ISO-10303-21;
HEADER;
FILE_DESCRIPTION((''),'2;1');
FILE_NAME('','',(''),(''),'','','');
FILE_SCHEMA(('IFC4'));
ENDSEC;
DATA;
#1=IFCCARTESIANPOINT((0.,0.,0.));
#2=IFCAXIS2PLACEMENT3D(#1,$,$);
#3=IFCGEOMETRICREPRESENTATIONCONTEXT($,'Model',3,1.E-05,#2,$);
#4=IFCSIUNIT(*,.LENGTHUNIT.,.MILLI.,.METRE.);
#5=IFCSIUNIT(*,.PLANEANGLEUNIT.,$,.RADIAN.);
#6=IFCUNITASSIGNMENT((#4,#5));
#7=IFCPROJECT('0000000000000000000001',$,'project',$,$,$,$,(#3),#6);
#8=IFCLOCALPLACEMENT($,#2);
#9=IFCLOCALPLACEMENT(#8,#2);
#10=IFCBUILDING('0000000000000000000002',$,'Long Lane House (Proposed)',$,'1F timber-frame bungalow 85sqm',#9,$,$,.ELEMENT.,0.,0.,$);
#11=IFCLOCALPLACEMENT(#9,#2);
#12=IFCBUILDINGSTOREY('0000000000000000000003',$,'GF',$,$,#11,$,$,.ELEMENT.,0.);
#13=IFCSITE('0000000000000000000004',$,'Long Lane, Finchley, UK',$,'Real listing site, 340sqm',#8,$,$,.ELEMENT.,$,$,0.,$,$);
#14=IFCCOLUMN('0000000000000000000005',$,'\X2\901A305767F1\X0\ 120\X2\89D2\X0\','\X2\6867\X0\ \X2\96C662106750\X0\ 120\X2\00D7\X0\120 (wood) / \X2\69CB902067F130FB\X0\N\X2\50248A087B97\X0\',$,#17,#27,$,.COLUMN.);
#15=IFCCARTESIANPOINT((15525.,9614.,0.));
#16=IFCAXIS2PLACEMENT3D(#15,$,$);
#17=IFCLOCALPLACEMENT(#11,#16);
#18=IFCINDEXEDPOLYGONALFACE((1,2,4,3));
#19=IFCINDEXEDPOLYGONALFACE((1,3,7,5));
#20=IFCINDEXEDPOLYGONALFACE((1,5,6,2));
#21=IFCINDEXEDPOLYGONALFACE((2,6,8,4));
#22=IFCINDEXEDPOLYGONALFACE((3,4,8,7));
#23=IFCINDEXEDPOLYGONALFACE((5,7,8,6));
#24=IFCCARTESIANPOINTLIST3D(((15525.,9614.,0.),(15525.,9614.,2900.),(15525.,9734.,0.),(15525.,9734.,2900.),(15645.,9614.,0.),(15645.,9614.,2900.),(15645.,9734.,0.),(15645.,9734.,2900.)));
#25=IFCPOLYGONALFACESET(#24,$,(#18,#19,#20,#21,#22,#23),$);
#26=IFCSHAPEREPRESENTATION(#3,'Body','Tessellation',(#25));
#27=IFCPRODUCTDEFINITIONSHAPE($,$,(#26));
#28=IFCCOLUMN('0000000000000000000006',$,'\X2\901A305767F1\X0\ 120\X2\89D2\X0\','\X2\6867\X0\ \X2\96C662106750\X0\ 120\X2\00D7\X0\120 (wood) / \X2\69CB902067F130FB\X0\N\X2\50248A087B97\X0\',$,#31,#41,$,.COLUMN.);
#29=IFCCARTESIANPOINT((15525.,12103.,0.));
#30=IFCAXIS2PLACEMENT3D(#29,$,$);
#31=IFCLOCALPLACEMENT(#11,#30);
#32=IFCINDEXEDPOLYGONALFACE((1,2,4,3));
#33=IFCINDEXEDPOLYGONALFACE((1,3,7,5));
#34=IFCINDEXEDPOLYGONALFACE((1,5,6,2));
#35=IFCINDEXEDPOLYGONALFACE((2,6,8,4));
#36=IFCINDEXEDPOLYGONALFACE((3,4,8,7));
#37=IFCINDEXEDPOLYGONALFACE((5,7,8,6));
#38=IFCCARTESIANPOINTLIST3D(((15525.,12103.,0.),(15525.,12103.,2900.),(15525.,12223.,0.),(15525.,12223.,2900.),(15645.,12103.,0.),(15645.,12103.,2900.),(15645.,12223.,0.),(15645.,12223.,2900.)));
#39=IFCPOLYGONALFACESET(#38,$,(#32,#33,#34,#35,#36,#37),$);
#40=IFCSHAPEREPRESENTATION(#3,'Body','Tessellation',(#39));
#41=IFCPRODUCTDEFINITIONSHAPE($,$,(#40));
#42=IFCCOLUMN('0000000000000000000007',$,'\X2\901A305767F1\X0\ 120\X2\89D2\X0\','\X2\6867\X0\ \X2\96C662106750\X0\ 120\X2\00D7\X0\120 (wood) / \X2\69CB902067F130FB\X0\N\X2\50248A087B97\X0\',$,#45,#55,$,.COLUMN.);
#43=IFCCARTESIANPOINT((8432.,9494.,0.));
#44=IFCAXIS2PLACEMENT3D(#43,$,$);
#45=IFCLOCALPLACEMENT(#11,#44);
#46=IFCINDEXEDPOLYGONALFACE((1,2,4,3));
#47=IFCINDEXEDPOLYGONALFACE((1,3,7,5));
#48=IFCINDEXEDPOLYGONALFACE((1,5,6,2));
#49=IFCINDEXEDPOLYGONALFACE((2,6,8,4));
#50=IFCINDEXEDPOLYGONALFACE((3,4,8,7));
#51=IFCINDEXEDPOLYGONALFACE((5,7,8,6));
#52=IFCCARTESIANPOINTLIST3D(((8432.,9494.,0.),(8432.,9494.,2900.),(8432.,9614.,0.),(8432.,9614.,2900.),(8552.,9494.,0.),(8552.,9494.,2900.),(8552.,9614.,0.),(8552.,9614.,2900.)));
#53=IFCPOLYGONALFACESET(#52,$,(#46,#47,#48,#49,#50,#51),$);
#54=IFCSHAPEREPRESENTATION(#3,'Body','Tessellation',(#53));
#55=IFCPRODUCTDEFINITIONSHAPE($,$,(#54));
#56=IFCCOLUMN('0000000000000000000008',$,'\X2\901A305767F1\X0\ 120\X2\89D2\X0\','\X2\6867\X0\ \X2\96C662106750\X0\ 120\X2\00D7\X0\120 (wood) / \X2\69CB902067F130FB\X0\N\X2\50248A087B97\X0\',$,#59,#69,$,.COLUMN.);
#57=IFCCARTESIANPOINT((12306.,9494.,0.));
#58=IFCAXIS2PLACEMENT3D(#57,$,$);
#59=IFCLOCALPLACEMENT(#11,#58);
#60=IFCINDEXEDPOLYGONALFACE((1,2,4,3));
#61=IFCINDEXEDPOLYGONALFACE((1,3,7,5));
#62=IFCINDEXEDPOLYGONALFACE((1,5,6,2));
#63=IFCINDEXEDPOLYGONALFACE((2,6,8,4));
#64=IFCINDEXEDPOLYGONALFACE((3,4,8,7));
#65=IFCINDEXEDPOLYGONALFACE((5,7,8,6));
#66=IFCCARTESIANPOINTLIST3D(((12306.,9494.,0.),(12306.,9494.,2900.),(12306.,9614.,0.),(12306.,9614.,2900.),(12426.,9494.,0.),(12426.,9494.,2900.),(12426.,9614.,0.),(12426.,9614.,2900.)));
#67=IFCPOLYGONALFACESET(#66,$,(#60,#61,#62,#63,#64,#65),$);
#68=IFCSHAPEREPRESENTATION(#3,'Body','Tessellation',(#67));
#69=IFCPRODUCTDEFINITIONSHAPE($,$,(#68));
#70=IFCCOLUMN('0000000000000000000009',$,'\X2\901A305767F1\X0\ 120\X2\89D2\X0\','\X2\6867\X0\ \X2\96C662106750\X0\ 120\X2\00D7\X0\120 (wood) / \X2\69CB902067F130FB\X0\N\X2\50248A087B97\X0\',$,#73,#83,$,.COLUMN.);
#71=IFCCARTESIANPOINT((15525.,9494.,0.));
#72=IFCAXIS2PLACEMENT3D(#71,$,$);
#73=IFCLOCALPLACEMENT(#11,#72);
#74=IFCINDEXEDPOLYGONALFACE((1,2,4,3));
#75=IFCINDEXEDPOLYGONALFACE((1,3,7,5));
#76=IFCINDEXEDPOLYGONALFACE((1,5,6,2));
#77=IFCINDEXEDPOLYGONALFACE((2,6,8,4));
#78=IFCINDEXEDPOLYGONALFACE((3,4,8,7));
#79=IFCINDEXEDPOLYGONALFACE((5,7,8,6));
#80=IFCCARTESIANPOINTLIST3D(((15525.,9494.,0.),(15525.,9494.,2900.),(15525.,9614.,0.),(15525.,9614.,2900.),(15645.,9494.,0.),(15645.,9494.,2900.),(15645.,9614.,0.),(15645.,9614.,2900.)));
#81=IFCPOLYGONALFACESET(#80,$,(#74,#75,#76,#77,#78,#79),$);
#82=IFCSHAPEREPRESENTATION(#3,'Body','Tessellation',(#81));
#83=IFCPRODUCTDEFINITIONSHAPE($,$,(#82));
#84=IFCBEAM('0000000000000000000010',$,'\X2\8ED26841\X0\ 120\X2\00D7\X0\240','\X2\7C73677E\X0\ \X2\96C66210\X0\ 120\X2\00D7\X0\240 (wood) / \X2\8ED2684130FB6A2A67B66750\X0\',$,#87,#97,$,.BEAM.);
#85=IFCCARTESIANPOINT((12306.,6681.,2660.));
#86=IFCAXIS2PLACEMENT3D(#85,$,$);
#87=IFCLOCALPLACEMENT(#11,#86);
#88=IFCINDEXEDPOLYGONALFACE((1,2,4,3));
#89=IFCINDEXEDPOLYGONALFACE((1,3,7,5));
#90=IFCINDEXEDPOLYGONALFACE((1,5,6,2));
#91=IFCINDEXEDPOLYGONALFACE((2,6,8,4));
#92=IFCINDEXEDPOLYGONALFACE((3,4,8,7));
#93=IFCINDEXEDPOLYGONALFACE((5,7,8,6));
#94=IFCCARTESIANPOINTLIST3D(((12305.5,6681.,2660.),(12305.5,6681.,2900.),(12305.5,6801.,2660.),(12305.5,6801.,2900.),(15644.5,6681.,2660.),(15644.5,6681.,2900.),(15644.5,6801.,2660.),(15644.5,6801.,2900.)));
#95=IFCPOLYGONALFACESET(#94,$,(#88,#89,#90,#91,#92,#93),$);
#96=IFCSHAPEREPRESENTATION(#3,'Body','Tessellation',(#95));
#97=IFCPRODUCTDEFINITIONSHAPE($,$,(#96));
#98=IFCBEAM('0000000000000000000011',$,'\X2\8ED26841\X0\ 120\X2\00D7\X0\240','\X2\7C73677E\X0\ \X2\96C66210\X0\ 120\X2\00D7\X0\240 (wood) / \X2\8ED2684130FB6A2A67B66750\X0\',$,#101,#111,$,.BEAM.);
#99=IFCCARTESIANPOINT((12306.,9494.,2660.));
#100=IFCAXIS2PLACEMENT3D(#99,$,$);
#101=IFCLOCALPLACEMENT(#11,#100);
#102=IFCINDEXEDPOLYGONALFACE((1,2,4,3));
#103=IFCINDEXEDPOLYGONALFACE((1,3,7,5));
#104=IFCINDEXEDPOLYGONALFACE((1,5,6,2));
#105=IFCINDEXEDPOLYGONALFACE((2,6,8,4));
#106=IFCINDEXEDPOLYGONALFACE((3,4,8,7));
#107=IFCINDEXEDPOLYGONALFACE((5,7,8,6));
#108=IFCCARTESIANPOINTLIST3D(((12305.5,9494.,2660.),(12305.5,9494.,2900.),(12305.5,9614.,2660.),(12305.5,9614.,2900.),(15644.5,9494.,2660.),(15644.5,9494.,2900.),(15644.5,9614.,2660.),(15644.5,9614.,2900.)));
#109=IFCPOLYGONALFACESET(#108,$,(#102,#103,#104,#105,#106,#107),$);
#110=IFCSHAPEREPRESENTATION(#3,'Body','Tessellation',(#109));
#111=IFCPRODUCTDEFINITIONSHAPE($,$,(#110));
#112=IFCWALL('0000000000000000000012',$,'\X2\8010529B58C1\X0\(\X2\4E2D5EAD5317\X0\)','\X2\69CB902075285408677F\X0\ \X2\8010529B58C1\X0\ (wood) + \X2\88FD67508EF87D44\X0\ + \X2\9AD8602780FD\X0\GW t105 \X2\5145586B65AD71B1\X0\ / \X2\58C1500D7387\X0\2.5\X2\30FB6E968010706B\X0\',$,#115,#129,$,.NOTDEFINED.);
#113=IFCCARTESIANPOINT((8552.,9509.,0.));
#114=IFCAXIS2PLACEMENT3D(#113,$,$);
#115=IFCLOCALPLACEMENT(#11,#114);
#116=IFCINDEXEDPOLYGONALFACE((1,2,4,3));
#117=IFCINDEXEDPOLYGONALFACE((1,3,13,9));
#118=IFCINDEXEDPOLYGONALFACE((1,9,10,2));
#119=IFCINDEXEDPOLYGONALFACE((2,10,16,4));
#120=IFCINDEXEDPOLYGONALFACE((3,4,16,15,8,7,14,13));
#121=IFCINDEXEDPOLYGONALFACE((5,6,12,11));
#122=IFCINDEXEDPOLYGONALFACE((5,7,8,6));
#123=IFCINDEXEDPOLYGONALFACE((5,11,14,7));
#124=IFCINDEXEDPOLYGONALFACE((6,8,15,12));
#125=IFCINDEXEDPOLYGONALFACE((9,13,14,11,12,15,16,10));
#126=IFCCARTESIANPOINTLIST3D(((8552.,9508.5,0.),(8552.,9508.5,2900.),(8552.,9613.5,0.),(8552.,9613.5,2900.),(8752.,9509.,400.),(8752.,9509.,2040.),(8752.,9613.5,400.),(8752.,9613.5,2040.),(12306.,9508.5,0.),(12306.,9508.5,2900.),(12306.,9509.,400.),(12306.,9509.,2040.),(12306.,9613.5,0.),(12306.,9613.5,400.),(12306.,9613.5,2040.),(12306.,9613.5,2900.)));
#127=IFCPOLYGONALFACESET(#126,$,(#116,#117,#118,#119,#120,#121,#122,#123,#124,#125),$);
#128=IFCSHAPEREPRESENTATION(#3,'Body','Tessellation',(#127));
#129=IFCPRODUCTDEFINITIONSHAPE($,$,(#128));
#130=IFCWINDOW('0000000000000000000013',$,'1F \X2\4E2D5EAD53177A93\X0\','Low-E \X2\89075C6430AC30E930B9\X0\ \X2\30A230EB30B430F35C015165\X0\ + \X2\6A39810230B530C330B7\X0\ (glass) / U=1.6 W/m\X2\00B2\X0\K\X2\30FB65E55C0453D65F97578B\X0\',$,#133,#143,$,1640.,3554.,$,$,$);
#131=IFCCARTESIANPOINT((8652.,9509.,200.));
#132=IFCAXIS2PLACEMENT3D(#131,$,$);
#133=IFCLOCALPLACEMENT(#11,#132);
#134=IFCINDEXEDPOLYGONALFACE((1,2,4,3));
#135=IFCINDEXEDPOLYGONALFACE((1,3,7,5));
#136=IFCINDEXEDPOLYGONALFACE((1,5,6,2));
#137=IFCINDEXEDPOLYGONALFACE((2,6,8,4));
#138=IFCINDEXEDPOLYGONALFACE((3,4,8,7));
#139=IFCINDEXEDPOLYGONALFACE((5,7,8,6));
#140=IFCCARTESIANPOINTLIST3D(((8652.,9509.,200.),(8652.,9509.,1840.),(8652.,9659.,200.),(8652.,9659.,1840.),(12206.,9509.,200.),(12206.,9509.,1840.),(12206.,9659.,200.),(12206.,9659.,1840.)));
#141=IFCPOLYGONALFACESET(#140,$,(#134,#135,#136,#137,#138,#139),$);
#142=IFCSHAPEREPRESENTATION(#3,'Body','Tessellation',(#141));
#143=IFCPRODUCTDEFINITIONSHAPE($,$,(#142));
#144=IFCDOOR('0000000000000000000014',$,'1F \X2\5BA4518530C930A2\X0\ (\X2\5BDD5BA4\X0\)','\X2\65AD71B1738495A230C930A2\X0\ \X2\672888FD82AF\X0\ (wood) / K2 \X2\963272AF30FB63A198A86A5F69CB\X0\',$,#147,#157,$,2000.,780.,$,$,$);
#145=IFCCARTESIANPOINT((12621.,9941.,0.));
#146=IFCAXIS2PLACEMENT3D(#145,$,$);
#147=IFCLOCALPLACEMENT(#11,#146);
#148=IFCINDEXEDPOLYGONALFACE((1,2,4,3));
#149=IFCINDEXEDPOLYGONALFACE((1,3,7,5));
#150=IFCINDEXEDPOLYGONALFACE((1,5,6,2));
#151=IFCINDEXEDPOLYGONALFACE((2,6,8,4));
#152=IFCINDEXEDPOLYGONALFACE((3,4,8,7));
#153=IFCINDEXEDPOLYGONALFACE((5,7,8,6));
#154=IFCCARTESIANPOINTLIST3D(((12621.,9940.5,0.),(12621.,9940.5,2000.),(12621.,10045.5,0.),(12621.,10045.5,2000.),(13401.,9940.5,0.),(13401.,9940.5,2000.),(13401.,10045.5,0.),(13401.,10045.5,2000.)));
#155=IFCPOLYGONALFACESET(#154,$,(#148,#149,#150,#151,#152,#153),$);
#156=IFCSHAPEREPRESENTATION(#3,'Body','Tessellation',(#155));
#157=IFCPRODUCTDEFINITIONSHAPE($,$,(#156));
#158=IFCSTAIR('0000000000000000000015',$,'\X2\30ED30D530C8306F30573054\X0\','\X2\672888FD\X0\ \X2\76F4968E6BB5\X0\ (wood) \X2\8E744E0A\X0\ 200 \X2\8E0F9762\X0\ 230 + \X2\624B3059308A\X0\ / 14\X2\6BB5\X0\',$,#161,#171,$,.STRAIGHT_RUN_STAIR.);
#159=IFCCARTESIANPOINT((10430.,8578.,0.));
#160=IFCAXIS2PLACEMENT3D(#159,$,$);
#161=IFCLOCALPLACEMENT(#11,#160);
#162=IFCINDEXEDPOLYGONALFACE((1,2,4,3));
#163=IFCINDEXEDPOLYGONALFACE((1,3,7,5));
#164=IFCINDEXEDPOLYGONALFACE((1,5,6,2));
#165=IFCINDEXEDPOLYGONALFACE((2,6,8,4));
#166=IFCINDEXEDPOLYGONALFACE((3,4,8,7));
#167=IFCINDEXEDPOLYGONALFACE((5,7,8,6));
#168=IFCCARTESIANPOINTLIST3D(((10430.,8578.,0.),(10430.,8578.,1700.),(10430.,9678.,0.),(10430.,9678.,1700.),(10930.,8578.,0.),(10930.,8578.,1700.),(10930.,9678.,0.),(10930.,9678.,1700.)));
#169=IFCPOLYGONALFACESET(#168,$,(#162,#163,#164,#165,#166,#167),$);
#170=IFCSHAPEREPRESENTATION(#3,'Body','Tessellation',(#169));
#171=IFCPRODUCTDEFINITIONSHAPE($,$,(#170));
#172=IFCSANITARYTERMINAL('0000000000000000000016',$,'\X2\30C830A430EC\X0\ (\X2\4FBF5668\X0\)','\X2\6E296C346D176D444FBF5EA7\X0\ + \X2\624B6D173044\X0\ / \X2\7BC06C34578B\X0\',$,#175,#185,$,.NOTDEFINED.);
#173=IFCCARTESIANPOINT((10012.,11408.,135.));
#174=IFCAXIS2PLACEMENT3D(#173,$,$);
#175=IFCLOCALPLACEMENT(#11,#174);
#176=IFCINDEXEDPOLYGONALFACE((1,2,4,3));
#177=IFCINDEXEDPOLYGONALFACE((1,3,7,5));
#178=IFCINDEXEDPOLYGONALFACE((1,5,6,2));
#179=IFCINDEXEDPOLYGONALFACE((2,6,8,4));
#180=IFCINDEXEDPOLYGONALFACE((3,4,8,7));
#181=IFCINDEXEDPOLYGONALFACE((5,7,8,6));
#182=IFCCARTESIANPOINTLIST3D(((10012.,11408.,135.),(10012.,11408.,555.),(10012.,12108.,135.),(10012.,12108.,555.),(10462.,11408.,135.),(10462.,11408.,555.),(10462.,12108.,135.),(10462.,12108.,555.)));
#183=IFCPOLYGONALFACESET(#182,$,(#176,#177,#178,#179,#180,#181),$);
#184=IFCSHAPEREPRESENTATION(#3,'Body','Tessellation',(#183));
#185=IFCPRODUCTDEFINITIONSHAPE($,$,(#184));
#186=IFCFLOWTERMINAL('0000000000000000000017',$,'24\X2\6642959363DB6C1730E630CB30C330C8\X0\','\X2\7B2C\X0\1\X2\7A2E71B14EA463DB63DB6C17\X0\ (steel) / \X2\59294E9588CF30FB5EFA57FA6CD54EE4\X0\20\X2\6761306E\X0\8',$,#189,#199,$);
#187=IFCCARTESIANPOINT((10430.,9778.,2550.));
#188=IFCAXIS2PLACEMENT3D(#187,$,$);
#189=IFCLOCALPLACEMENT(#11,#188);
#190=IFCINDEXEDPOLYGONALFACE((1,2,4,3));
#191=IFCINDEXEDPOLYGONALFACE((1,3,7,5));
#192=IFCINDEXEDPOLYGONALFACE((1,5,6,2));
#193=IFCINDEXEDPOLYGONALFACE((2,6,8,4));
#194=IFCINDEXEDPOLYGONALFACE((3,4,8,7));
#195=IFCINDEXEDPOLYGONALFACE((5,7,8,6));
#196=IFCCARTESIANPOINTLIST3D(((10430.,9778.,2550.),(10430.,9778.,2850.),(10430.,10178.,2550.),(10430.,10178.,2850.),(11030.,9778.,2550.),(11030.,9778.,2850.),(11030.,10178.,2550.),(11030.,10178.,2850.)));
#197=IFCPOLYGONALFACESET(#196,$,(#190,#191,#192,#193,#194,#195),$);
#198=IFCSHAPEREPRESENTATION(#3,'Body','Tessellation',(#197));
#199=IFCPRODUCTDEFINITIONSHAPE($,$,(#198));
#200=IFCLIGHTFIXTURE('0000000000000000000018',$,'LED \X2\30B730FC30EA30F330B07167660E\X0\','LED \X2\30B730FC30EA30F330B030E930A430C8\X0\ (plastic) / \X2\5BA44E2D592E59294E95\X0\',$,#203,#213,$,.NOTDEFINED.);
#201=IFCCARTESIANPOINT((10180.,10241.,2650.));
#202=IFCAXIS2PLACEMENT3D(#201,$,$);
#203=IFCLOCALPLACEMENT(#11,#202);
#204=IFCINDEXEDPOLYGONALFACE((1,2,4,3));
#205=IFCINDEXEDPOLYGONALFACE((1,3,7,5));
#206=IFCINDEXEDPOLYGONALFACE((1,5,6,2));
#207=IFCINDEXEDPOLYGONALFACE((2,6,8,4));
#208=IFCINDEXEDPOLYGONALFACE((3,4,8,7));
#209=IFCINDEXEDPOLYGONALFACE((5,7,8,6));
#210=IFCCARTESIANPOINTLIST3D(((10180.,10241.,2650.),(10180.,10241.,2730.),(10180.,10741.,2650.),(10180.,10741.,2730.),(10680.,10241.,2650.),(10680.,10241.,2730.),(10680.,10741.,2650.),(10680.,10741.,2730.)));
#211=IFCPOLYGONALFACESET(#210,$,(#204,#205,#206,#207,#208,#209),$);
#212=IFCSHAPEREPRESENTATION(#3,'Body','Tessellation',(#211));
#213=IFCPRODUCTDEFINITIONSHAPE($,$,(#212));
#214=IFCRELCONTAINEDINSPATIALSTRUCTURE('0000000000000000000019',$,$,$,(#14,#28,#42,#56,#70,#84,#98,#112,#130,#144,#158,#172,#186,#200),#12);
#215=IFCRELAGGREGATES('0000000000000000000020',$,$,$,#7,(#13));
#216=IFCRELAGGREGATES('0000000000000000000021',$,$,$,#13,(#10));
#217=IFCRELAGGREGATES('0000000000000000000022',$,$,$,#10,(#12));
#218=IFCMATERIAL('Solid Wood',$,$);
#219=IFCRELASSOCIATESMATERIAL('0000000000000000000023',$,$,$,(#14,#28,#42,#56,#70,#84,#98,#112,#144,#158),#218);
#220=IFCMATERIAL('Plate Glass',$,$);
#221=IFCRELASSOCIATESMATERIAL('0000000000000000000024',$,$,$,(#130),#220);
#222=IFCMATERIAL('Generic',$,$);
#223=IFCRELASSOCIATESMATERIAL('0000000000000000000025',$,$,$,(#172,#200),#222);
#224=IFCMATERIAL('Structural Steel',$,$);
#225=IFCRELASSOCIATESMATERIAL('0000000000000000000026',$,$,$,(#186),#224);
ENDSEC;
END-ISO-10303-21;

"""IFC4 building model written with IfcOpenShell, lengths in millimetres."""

from ifc_helpers import new_model, si_unit, frame, frame_2d, origin, place, context, project, spatial, rectangle, extrude, material, element, fill, save


model = new_model("IFC4")

# Units and contexts
model_context = context("Model", 3, precision=1e-05, world=origin())
ifc_project = project(units=[si_unit("LENGTHUNIT", "METRE", prefix="MILLI"), si_unit("PLANEANGLEUNIT", "RADIAN")], contexts=[model_context])

# Site, building, storey
site_placement = place(None, origin())
site = spatial("IfcSite", under=ifc_project, at=site_placement, Name="Long Lane, Finchley, UK", ObjectType="Real listing site, 340sqm", CompositionType="ELEMENT", RefElevation=0.0)
building_placement = place(site_placement, origin())
building = spatial("IfcBuilding", under=site, at=building_placement, Name="Long Lane House (Proposed)", ObjectType="1F timber-frame bungalow 85sqm", CompositionType="ELEMENT", ElevationOfRefHeight=0.0, ElevationOfTerrain=0.0)
storey_placement = place(building_placement, origin())
storey = spatial("IfcBuildingStorey", under=building, at=storey_placement, Name="GF", CompositionType="ELEMENT", Elevation=0.0)

# Columns
ifc_material_1 = material(Name="Solid Wood")
column_1_placement = place(storey_placement, frame((15525.0, 9614.0, 0.0)))
element("IfcColumn", 1, at=column_1_placement, inside=storey, material=ifc_material_1, Name="通し柱 120角", Description="桧 集成材 120×120 (wood) / 構造柱・N値計算", PredefinedType="COLUMN", context=model_context, shape_type="SweptSolid", body=[
    extrude(rectangle(XDim=120.0, YDim=120.0, at=frame_2d((60.0, 60.0))), frame((15525.0, 9614.0, 0.0)), (0.0, 0.0, 1.0), 2900.0),
])
column_2_placement = place(storey_placement, frame((15525.0, 12103.0, 0.0)))
element("IfcColumn", 2, at=column_2_placement, inside=storey, material=ifc_material_1, Name="通し柱 120角", Description="桧 集成材 120×120 (wood) / 構造柱・N値計算", PredefinedType="COLUMN", context=model_context, shape_type="SweptSolid", body=[
    extrude(rectangle(XDim=120.0, YDim=120.0, at=frame_2d((60.0, 60.0))), frame((15525.0, 12103.0, 0.0)), (0.0, 0.0, 1.0), 2900.0),
])
column_3_placement = place(storey_placement, frame((8432.0, 9494.0, 0.0)))
element("IfcColumn", 3, at=column_3_placement, inside=storey, material=ifc_material_1, Name="通し柱 120角", Description="桧 集成材 120×120 (wood) / 構造柱・N値計算", PredefinedType="COLUMN", context=model_context, shape_type="SweptSolid", body=[
    extrude(rectangle(XDim=120.0, YDim=120.0, at=frame_2d((60.0, 60.0))), frame((8432.0, 9494.0, 0.0)), (0.0, 0.0, 1.0), 2900.0),
])
column_4_placement = place(storey_placement, frame((12306.0, 9494.0, 0.0)))
element("IfcColumn", 4, at=column_4_placement, inside=storey, material=ifc_material_1, Name="通し柱 120角", Description="桧 集成材 120×120 (wood) / 構造柱・N値計算", PredefinedType="COLUMN", context=model_context, shape_type="SweptSolid", body=[
    extrude(rectangle(XDim=120.0, YDim=120.0, at=frame_2d((60.0, 60.0))), frame((12306.0, 9494.0, 0.0)), (0.0, 0.0, 1.0), 2900.0),
])
column_5_placement = place(storey_placement, frame((15525.0, 9494.0, 0.0)))
element("IfcColumn", 5, at=column_5_placement, inside=storey, material=ifc_material_1, Name="通し柱 120角", Description="桧 集成材 120×120 (wood) / 構造柱・N値計算", PredefinedType="COLUMN", context=model_context, shape_type="SweptSolid", body=[
    extrude(rectangle(XDim=120.0, YDim=120.0, at=frame_2d((60.0, 60.0))), frame((15525.0, 9494.0, 0.0)), (0.0, 0.0, 1.0), 2900.0),
])

# Beams
beam_1_placement = place(storey_placement, frame((12306.0, 6681.0, 2660.0)))
element("IfcBeam", 6, at=beam_1_placement, inside=storey, material=ifc_material_1, Name="軒桁 120×240", Description="米松 集成 120×240 (wood) / 軒桁・横架材", PredefinedType="BEAM", context=model_context, shape_type="SweptSolid", body=[
    extrude(rectangle(XDim=3339.0, YDim=120.0, at=frame_2d((1669.0, 60.0))), frame((12306.0, 6681.0, 2660.0)), (0.0, 0.0, 1.0), 240.0),
])
beam_2_placement = place(storey_placement, frame((12306.0, 9494.0, 2660.0)))
element("IfcBeam", 7, at=beam_2_placement, inside=storey, material=ifc_material_1, Name="軒桁 120×240", Description="米松 集成 120×240 (wood) / 軒桁・横架材", PredefinedType="BEAM", context=model_context, shape_type="SweptSolid", body=[
    extrude(rectangle(XDim=3339.0, YDim=120.0, at=frame_2d((1669.0, 60.0))), frame((12306.0, 9494.0, 2660.0)), (0.0, 0.0, 1.0), 240.0),
])

# Wall, opening, window
wall_1_placement = place(storey_placement, frame((8552.0, 9509.0, 0.0)))
wall_1 = element("IfcWall", 8, at=wall_1_placement, inside=storey, material=ifc_material_1, Name="耐力壁(中庭北)", Description="構造用合板 耐力壁 (wood) + 製材軸組 + 高性能GW t105 充填断熱 / 壁倍率2.5・準耐火", PredefinedType="NOTDEFINED", context=model_context, shape_type="SweptSolid", body=[
    extrude(rectangle(XDim=3754.0, YDim=105.0, at=frame_2d((1877.0, 52.0))), frame((8552.0, 9509.0, 0.0)), (0.0, 0.0, 1.0), 2900.0),
])
opening_placement = place(storey_placement, frame((8652.0, 9509.0, 200.0)))
opening = element("IfcOpeningElement", 9, at=opening_placement, cuts=wall_1, PredefinedType="NOTDEFINED", context=model_context, shape_type="SweptSolid", body=[
    extrude(rectangle(XDim=3554.0, YDim=150.0, at=frame_2d((1777.0, 75.0))), frame((8652.0, 9509.0, 200.0)), (0.0, 0.0, 1.0), 1640.0),
])
ifc_material_2 = material(Name="Plate Glass")
window_placement = place(storey_placement, frame((8652.0, 9509.0, 200.0)))
window = element("IfcWindow", 10, at=window_placement, inside=storey, material=ifc_material_2, Name="1F 中庭北窓", Description="Low-E 複層ガラス アルゴン封入 + 樹脂サッシ (glass) / U=1.6 W/m²K・日射取得型", OverallHeight=1640.0, OverallWidth=3554.0, context=model_context, shape_type="SweptSolid", body=[
    extrude(rectangle(XDim=3554.0, YDim=150.0, at=frame_2d((1777.0, 75.0))), frame((8652.0, 9509.0, 200.0)), (0.0, 0.0, 1.0), 1640.0),
])
fill(opening, window)

# Door
door_placement = place(storey_placement, frame((12621.0, 9941.0, 0.0)))
element("IfcDoor", 11, at=door_placement, inside=storey, material=ifc_material_1, Name="1F 室内ドア (寝室)", Description="断熱玄関ドア 木製芯 (wood) / K2 防犯・採風機構", OverallHeight=2000.0, OverallWidth=780.0, context=model_context, shape_type="SweptSolid", body=[
    extrude(rectangle(XDim=780.0, YDim=105.0, at=frame_2d((390.0, 52.0))), frame((12621.0, 9941.0, 0.0)), (0.0, 0.0, 1.0), 2000.0),
])

# Stair
stair_placement = place(storey_placement, frame((10430.0, 8578.0, 0.0)))
element("IfcStair", 12, at=stair_placement, inside=storey, material=ifc_material_1, Name="ロフトはしご", Description="木製 直階段 (wood) 蹴上 200 踏面 230 + 手すり / 14段", PredefinedType="STRAIGHT_RUN_STAIR", context=model_context, shape_type="SweptSolid", body=[
    extrude(rectangle(XDim=500.0, YDim=1100.0, at=frame_2d((250.0, 550.0))), frame((10430.0, 8578.0, 0.0)), (0.0, 0.0, 1.0), 1700.0),
])

# Shared definitions
ifc_material_3 = material(Name="Generic")

# Sanitary terminal
sanitary_terminal_placement = place(storey_placement, frame((10012.0, 11408.0, 135.0)))
element("IfcSanitaryTerminal", 13, at=sanitary_terminal_placement, inside=storey, material=ifc_material_3, Name="トイレ (便器)", Description="温水洗浄便座 + 手洗い / 節水型", PredefinedType="NOTDEFINED", context=model_context, shape_type="SweptSolid", body=[
    extrude(rectangle(XDim=450.0, YDim=700.0, at=frame_2d((225.0, 350.0))), frame((10012.0, 11408.0, 135.0)), (0.0, 0.0, 1.0), 420.0),
])

# Flow terminal
ifc_material_4 = material(Name="Structural Steel")
flow_terminal_placement = place(storey_placement, frame((10430.0, 9778.0, 2550.0)))
element("IfcFlowTerminal", 14, at=flow_terminal_placement, inside=storey, material=ifc_material_4, Name="24時間換気ユニット", Description="第1種熱交換換気 (steel) / 天井裏・建基法令20条の8", context=model_context, shape_type="SweptSolid", body=[
    extrude(rectangle(XDim=600.0, YDim=400.0, at=frame_2d((300.0, 200.0))), frame((10430.0, 9778.0, 2550.0)), (0.0, 0.0, 1.0), 300.0),
])

# Light fixture
light_fixture_1_placement = place(storey_placement, frame((10180.0, 10241.0, 2650.0)))
element("IfcLightFixture", 15, at=light_fixture_1_placement, inside=storey, material=ifc_material_3, Name="LED シーリング照明", Description="LED シーリングライト (plastic) / 室中央天井", PredefinedType="NOTDEFINED", context=model_context, shape_type="SweptSolid", body=[
    extrude(rectangle(XDim=500.0, YDim=500.0, at=frame_2d((250.0, 250.0))), frame((10180.0, 10241.0, 2650.0)), (0.0, 0.0, 1.0), 80.0),
])

save(model, "model.ifc")
